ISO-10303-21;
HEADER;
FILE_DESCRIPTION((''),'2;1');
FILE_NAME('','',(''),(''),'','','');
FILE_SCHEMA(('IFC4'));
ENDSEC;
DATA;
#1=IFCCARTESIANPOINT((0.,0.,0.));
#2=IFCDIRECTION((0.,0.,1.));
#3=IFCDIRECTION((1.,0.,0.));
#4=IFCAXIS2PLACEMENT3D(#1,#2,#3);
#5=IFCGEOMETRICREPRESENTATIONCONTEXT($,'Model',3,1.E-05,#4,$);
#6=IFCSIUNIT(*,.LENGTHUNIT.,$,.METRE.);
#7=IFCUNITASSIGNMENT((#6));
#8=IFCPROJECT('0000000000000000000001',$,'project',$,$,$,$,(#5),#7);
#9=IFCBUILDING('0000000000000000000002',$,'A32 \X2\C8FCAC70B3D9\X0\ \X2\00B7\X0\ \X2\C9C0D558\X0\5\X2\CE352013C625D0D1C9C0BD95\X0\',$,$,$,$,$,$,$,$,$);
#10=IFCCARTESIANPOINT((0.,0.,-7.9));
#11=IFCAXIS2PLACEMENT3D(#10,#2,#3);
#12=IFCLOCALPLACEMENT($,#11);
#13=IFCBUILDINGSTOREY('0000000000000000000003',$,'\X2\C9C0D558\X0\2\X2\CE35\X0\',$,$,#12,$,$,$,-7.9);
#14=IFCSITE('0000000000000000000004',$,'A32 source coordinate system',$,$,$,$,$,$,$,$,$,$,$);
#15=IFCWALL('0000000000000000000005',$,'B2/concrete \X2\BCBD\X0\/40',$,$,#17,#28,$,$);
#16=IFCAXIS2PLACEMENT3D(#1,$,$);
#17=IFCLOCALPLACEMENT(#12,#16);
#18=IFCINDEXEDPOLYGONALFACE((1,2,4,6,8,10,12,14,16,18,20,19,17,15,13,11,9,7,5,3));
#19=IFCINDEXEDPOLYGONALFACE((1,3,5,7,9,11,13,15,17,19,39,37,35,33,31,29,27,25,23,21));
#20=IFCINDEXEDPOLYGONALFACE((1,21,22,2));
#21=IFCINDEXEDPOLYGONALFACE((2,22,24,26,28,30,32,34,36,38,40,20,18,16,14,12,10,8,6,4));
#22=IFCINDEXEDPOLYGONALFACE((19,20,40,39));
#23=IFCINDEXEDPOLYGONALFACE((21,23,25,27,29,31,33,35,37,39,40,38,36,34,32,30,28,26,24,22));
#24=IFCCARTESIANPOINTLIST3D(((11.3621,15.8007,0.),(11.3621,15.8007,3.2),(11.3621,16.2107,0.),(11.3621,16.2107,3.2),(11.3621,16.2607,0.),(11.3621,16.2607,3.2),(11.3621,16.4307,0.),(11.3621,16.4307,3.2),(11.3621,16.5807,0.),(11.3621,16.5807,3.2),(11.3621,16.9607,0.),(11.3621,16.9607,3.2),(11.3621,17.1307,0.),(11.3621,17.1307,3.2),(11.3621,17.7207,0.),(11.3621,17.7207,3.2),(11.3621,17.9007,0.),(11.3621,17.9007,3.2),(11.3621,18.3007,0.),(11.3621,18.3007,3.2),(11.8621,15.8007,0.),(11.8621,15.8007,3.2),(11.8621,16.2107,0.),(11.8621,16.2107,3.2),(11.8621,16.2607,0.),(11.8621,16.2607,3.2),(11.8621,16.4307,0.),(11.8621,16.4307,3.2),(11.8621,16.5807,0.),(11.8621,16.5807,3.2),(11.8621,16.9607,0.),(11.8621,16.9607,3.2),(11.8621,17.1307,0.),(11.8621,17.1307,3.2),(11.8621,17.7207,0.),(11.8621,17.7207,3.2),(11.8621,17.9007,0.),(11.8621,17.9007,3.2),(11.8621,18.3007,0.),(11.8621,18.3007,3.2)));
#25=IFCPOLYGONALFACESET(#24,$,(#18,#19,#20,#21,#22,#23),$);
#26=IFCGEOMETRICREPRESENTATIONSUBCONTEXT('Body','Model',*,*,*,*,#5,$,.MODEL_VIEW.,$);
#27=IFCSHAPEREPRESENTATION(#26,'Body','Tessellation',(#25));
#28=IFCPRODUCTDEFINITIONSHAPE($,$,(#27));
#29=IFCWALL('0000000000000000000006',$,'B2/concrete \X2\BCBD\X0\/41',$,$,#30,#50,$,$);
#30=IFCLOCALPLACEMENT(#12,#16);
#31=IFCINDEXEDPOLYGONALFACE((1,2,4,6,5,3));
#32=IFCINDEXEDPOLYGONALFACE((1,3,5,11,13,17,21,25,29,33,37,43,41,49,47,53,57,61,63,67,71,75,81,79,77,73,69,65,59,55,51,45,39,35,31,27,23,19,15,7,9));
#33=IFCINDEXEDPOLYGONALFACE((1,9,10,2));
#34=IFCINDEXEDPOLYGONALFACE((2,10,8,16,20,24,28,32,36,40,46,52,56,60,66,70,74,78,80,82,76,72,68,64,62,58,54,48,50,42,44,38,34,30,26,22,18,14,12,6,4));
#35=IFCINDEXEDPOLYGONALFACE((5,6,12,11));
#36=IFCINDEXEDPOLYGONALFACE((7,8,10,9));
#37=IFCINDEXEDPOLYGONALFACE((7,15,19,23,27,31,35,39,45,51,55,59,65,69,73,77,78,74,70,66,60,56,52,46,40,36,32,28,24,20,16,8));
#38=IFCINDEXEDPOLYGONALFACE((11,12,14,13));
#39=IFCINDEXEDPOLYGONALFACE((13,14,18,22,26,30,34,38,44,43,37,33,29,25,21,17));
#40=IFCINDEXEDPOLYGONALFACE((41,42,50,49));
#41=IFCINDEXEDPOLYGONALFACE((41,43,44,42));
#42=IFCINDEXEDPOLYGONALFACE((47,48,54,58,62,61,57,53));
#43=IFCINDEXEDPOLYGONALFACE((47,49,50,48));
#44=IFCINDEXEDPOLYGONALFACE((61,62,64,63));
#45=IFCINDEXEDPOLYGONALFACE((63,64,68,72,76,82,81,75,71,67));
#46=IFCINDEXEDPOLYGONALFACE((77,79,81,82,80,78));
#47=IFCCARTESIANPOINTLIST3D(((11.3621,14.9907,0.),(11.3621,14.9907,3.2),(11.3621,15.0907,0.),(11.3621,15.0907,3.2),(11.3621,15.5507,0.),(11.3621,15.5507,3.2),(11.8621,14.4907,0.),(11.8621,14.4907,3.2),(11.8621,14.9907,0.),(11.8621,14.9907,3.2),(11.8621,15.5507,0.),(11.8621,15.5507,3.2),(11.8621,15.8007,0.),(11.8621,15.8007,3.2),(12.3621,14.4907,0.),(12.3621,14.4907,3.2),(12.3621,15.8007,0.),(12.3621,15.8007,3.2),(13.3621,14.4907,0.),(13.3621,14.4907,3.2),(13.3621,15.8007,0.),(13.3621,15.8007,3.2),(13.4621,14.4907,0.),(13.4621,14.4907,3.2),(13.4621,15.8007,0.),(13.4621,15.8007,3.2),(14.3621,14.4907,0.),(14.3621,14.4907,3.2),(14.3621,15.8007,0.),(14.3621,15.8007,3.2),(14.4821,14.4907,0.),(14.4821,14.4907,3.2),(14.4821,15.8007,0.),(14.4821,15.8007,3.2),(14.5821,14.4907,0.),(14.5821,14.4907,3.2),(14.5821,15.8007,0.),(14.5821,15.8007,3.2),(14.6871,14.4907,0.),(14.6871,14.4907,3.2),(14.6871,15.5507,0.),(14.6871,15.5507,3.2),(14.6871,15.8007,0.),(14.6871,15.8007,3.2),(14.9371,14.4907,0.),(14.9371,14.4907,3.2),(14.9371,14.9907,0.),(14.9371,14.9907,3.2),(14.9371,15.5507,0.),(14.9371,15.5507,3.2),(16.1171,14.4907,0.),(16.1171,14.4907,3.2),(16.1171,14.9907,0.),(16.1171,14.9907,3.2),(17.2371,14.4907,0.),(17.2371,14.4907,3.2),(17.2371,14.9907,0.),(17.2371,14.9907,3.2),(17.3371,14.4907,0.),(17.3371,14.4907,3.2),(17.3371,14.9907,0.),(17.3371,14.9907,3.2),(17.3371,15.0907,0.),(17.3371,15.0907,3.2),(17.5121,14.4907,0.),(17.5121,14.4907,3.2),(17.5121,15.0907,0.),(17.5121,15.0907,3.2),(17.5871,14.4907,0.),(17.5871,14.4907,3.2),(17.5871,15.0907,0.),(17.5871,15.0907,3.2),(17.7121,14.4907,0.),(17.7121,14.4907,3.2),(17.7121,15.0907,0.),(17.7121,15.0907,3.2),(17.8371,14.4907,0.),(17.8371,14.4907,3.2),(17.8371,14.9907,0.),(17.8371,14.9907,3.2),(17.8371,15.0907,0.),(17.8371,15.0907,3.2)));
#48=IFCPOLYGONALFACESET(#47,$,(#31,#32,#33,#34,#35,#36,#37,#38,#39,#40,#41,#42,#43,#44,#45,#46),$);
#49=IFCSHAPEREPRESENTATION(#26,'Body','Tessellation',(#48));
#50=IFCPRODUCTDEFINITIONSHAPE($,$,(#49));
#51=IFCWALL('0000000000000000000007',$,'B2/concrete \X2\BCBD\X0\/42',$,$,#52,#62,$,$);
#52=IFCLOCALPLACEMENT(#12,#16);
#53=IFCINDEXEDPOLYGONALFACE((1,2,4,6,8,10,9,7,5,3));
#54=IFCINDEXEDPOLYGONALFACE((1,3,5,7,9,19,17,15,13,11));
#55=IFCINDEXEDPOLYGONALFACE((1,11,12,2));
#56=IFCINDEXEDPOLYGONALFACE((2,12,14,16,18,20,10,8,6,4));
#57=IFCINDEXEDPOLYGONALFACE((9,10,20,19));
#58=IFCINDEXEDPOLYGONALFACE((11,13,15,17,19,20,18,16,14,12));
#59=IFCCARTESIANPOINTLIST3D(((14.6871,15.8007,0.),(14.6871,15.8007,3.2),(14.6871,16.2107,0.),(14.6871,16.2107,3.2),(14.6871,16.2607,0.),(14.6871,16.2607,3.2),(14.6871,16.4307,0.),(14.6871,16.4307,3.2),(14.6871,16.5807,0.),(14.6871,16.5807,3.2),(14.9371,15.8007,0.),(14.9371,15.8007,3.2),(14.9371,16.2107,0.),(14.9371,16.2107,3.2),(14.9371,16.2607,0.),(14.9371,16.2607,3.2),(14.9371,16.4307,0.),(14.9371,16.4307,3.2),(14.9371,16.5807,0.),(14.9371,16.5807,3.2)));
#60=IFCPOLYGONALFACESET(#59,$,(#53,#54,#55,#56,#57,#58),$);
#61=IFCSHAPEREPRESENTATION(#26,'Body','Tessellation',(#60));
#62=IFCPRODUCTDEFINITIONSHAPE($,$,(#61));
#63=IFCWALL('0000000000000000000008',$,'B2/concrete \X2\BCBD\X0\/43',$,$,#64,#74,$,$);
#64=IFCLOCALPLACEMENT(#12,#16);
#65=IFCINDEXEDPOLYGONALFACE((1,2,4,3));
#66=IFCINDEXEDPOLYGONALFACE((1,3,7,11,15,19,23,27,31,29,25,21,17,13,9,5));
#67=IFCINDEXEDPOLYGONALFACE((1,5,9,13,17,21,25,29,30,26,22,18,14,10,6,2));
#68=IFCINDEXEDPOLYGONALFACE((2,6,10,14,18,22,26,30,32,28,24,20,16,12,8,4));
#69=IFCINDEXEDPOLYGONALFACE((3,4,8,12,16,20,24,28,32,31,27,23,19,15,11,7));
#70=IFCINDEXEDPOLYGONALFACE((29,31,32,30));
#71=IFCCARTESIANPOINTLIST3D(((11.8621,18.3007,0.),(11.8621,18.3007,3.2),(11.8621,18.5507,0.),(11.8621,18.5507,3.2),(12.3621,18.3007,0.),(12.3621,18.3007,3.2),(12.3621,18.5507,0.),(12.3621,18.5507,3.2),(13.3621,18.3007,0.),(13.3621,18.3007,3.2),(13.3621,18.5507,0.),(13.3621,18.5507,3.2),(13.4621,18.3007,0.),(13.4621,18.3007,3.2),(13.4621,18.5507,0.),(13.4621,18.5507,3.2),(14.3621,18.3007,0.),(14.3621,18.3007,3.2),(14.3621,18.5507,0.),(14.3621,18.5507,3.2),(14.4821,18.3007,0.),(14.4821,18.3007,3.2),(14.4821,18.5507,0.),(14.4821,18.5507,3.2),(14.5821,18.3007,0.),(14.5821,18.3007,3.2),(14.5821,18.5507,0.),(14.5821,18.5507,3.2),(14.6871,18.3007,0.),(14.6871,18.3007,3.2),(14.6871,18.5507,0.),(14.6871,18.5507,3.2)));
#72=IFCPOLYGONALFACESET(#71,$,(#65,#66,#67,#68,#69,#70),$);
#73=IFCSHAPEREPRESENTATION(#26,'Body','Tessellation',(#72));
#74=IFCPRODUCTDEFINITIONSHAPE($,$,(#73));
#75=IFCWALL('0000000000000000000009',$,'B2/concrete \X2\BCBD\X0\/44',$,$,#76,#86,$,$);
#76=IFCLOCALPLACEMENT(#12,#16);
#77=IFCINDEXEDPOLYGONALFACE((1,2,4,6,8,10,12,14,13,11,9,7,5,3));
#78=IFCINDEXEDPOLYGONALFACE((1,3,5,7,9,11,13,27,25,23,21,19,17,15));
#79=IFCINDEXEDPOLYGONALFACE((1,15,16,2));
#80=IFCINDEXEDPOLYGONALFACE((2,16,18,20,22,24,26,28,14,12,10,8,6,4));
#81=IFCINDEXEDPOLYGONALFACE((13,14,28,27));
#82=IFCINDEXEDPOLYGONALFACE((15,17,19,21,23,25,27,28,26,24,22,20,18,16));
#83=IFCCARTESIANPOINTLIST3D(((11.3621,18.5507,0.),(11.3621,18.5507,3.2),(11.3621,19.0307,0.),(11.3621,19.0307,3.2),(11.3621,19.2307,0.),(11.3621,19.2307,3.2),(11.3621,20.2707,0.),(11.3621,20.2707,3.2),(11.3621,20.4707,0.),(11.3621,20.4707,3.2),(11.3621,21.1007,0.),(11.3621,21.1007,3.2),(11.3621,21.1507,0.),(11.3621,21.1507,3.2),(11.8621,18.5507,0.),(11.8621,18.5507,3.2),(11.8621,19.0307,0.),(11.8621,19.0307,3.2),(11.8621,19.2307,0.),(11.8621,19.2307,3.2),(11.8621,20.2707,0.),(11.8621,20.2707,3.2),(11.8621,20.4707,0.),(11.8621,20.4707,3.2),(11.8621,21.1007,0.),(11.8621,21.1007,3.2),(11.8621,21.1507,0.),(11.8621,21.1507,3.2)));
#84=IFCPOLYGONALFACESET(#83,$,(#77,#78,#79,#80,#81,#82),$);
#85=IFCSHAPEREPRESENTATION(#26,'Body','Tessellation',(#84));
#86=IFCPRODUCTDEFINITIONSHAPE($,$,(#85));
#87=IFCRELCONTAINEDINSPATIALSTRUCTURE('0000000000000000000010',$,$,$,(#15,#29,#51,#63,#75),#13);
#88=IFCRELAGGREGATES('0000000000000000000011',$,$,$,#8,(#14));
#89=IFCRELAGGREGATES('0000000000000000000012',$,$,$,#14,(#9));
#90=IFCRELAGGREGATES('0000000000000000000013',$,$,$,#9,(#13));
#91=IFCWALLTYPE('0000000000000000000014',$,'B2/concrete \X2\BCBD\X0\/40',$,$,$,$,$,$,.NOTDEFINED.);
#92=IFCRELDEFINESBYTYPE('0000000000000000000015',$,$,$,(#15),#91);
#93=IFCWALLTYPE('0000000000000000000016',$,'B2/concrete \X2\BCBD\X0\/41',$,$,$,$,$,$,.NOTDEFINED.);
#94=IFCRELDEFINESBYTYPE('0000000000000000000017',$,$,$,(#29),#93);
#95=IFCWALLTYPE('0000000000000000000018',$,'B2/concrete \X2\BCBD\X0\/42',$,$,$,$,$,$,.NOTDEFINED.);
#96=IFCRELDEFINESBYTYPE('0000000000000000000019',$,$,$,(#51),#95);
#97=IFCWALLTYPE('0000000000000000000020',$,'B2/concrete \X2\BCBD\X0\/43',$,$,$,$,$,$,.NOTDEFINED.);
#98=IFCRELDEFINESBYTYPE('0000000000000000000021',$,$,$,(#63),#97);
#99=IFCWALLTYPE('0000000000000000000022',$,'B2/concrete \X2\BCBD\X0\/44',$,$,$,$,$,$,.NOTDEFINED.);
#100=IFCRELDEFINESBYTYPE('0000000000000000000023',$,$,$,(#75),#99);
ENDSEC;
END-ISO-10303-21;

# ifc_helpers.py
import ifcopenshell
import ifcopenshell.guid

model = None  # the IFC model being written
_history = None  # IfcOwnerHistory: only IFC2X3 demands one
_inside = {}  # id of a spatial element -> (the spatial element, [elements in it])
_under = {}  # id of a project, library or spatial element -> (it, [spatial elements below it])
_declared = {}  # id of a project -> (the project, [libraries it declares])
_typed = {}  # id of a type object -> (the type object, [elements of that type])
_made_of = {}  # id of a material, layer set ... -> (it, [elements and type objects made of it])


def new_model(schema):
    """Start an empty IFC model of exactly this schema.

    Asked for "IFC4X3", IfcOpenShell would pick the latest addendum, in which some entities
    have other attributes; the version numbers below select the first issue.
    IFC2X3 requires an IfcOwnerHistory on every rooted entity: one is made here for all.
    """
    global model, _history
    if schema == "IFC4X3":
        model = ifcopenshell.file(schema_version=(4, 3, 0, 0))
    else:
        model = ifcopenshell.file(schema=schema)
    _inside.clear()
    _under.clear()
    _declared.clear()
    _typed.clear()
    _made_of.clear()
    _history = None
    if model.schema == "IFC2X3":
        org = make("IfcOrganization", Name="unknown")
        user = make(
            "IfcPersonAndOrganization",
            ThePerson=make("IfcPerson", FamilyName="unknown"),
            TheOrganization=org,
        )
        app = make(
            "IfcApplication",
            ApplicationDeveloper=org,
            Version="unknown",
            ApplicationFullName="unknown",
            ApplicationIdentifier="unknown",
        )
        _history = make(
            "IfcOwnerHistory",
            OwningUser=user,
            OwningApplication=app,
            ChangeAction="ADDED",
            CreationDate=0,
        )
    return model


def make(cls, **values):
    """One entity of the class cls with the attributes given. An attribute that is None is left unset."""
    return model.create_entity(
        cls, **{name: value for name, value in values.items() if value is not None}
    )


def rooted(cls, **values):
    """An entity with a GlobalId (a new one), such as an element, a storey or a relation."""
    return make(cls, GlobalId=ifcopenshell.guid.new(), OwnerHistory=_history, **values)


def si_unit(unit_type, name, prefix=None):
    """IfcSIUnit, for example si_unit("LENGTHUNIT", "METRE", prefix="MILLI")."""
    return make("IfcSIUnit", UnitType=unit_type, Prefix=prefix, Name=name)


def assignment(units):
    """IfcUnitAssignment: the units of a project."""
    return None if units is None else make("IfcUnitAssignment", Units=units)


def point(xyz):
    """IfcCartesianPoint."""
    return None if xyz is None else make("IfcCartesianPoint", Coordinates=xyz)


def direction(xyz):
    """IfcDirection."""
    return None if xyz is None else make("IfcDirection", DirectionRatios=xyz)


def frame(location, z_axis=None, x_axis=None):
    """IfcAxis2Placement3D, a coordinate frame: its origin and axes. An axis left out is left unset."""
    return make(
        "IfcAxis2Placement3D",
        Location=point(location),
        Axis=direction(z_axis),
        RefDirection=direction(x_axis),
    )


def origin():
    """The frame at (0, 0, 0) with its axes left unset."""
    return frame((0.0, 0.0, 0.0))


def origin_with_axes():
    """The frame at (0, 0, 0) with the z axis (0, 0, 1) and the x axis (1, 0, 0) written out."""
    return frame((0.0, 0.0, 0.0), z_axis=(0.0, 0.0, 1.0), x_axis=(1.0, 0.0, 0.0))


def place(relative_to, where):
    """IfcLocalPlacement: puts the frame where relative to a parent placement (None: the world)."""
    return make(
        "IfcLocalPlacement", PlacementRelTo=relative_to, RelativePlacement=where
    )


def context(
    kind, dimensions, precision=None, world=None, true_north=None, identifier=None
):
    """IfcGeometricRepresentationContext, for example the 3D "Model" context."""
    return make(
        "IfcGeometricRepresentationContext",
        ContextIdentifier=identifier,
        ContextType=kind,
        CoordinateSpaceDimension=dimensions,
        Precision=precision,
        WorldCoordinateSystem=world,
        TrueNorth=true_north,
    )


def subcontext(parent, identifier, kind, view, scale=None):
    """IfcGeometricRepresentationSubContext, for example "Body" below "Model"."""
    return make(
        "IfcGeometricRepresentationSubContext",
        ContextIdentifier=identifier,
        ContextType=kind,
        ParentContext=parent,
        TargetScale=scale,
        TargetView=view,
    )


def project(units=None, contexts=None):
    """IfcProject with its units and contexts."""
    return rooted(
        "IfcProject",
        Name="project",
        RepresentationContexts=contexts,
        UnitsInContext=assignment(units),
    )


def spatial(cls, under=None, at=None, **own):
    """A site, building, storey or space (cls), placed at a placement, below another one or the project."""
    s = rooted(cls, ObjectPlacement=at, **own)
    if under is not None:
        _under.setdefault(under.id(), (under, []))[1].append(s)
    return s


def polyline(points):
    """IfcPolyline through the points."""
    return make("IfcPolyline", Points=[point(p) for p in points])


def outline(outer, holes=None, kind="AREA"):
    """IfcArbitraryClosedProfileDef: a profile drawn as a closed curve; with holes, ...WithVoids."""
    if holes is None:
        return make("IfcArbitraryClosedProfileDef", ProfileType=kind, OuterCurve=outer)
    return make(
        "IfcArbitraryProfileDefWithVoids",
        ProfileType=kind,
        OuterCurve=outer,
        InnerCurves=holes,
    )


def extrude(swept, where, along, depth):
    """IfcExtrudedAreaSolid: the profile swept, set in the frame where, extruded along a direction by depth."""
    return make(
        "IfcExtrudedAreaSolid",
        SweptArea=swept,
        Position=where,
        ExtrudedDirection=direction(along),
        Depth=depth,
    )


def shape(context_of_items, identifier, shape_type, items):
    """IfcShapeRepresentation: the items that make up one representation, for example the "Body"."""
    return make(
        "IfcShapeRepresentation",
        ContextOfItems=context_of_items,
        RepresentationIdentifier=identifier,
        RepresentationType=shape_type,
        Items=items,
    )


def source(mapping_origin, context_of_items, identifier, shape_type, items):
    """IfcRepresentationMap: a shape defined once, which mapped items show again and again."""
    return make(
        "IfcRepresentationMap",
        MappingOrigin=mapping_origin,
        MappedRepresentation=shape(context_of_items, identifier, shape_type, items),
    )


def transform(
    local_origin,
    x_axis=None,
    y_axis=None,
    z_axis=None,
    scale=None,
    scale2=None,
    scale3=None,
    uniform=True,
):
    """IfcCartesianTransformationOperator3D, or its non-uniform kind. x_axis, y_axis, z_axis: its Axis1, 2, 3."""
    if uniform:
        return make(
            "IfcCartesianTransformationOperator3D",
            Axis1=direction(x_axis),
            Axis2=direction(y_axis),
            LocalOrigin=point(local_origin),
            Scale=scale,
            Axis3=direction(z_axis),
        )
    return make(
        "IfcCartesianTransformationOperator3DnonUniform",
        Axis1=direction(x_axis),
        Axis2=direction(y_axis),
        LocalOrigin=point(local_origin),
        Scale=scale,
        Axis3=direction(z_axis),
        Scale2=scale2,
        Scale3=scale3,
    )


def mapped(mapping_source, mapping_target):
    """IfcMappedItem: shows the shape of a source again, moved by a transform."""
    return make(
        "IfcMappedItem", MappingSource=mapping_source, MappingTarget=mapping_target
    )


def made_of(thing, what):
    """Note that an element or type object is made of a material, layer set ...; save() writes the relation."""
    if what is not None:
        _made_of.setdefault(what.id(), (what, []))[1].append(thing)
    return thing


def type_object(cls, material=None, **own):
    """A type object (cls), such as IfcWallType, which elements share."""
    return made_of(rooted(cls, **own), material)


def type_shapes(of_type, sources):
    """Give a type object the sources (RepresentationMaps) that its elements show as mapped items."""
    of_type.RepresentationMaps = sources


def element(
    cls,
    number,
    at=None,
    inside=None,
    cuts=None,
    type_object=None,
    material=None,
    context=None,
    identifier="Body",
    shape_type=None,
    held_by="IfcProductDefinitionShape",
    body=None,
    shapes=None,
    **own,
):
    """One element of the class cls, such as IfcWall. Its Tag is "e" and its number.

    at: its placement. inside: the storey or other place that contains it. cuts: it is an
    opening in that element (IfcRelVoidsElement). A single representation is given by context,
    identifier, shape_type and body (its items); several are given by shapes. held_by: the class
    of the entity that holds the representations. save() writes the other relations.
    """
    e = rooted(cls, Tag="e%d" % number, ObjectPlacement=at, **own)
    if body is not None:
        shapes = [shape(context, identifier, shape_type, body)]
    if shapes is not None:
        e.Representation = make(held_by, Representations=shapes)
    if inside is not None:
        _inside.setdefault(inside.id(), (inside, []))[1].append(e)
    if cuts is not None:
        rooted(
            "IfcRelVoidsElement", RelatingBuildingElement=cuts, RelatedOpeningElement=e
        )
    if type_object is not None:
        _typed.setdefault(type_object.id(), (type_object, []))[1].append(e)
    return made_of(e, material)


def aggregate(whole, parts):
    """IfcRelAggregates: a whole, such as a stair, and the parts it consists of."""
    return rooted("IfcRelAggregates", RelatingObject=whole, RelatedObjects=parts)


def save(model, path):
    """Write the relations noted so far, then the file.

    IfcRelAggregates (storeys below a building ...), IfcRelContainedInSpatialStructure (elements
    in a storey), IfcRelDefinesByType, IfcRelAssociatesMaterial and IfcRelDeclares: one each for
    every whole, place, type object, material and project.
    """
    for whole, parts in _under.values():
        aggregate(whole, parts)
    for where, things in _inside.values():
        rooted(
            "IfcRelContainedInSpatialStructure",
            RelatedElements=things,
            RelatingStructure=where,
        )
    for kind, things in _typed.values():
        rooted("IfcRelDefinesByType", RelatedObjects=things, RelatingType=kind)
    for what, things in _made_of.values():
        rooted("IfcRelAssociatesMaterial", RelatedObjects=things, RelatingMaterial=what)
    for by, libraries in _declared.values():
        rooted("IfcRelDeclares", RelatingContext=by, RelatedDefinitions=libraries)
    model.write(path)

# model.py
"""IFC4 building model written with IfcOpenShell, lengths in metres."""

from ifc_helpers import new_model, si_unit, frame, origin, origin_with_axes, place, context, subcontext, project, spatial, polyline, outline, extrude, source, transform, mapped, type_object, type_shapes, element, save


model = new_model("IFC4")

# Units and contexts
model_context = context("Model", 3, precision=1e-05, world=origin_with_axes())
body_context = subcontext(model_context, "Body", "Model", "MODEL_VIEW")
ifc_project = project(units=[si_unit("LENGTHUNIT", "METRE")], contexts=[model_context])

# Site, building, storey
site = spatial("IfcSite", under=ifc_project, Name="A32 source coordinate system")
building = spatial("IfcBuilding", under=site, Name="A32 주거동 · 지하5층–옥탑지붕")
storey_placement = place(None, frame((0.0, 0.0, -7.9), z_axis=(0.0, 0.0, 1.0), x_axis=(1.0, 0.0, 0.0)))
storey = spatial("IfcBuildingStorey", under=building, at=storey_placement, Name="지하2층", Elevation=-7.9)

# Walls
wall_type_1 = type_object("IfcWallType", Name="B2/concrete 벽/40", PredefinedType="NOTDEFINED")
shared_shape_1 = source(origin(), body_context, "Body", "SweptSolid", [
    extrude(outline(polyline([(11.3621, 18.3007), (11.8621, 18.3007), (11.8621, 17.9007), (11.8621, 17.7207), (11.8621, 17.1307), (11.8621, 16.9607), (11.8621, 16.5807), (11.8621, 16.4307), (11.8621, 16.2607), (11.8621, 16.2107), (11.8621, 15.8007), (11.3621, 15.8007), (11.3621, 16.2107), (11.3621, 16.2607), (11.3621, 16.4307), (11.3621, 16.5807), (11.3621, 16.9607), (11.3621, 17.1307), (11.3621, 17.7207), (11.3621, 17.9007), (11.3621, 18.3007)])), origin(), (0.0, 0.0, 1.0), 3.2),
])
type_shapes(wall_type_1, [shared_shape_1])
wall_1_placement = place(storey_placement, origin_with_axes())
element("IfcWall", 1, at=wall_1_placement, inside=storey, type_object=wall_type_1, Name="B2/concrete 벽/40", context=body_context, shape_type="MappedRepresentation", body=[
    mapped(shared_shape_1, transform((0.0, 0.0, 0.0), scale=1.0)),
])
wall_type_2 = type_object("IfcWallType", Name="B2/concrete 벽/41", PredefinedType="NOTDEFINED")
shared_shape_2 = source(origin(), body_context, "Body", "SweptSolid", [
    extrude(outline(polyline([(13.4621, 15.8007), (14.3621, 15.8007), (14.4821, 15.8007), (14.5821, 15.8007), (14.6871, 15.8007), (14.6871, 15.5507), (14.9371, 15.5507), (14.9371, 14.9907), (16.1171, 14.9907), (17.2371, 14.9907), (17.3371, 14.9907), (17.3371, 15.0907), (17.5121, 15.0907), (17.5871, 15.0907), (17.7121, 15.0907), (17.8371, 15.0907), (17.8371, 14.9907), (17.8371, 14.4907), (17.7121, 14.4907), (17.5871, 14.4907), (17.5121, 14.4907), (17.3371, 14.4907), (17.2371, 14.4907), (16.1171, 14.4907), (14.9371, 14.4907), (14.6871, 14.4907), (14.5821, 14.4907), (14.4821, 14.4907), (14.3621, 14.4907), (13.4621, 14.4907), (13.3621, 14.4907), (12.3621, 14.4907), (11.8621, 14.4907), (11.8621, 14.9907), (11.3621, 14.9907), (11.3621, 15.0907), (11.3621, 15.5507), (11.8621, 15.5507), (11.8621, 15.8007), (12.3621, 15.8007), (13.3621, 15.8007), (13.4621, 15.8007)])), origin(), (0.0, 0.0, 1.0), 3.2),
])
type_shapes(wall_type_2, [shared_shape_2])
wall_2_placement = place(storey_placement, origin_with_axes())
element("IfcWall", 2, at=wall_2_placement, inside=storey, type_object=wall_type_2, Name="B2/concrete 벽/41", context=body_context, shape_type="MappedRepresentation", body=[
    mapped(shared_shape_2, transform((0.0, 0.0, 0.0), scale=1.0)),
])
wall_type_3 = type_object("IfcWallType", Name="B2/concrete 벽/42", PredefinedType="NOTDEFINED")
shared_shape_3 = source(origin(), body_context, "Body", "SweptSolid", [
    extrude(outline(polyline([(14.6871, 16.4307), (14.6871, 16.5807), (14.9371, 16.5807), (14.9371, 16.4307), (14.9371, 16.2607), (14.9371, 16.2107), (14.9371, 15.8007), (14.6871, 15.8007), (14.6871, 16.2107), (14.6871, 16.2607), (14.6871, 16.4307)])), origin(), (0.0, 0.0, 1.0), 3.2),
])
type_shapes(wall_type_3, [shared_shape_3])
wall_3_placement = place(storey_placement, origin_with_axes())
element("IfcWall", 3, at=wall_3_placement, inside=storey, type_object=wall_type_3, Name="B2/concrete 벽/42", context=body_context, shape_type="MappedRepresentation", body=[
    mapped(shared_shape_3, transform((0.0, 0.0, 0.0), scale=1.0)),
])
wall_type_4 = type_object("IfcWallType", Name="B2/concrete 벽/43", PredefinedType="NOTDEFINED")
shared_shape_4 = source(origin(), body_context, "Body", "SweptSolid", [
    extrude(outline(polyline([(13.3621, 18.5507), (13.4621, 18.5507), (14.3621, 18.5507), (14.4821, 18.5507), (14.5821, 18.5507), (14.6871, 18.5507), (14.6871, 18.3007), (14.5821, 18.3007), (14.4821, 18.3007), (14.3621, 18.3007), (13.4621, 18.3007), (13.3621, 18.3007), (12.3621, 18.3007), (11.8621, 18.3007), (11.8621, 18.5507), (12.3621, 18.5507), (13.3621, 18.5507)])), origin(), (0.0, 0.0, 1.0), 3.2),
])
type_shapes(wall_type_4, [shared_shape_4])
wall_4_placement = place(storey_placement, origin_with_axes())
element("IfcWall", 4, at=wall_4_placement, inside=storey, type_object=wall_type_4, Name="B2/concrete 벽/43", context=body_context, shape_type="MappedRepresentation", body=[
    mapped(shared_shape_4, transform((0.0, 0.0, 0.0), scale=1.0)),
])
wall_type_5 = type_object("IfcWallType", Name="B2/concrete 벽/44", PredefinedType="NOTDEFINED")
shared_shape_5 = source(origin(), body_context, "Body", "SweptSolid", [
    extrude(outline(polyline([(11.3621, 19.2307), (11.3621, 20.2707), (11.3621, 20.4707), (11.3621, 21.1007), (11.3621, 21.1507), (11.8621, 21.1507), (11.8621, 21.1007), (11.8621, 20.4707), (11.8621, 20.2707), (11.8621, 19.2307), (11.8621, 19.0307), (11.8621, 18.5507), (11.3621, 18.5507), (11.3621, 19.0307), (11.3621, 19.2307)])), origin(), (0.0, 0.0, 1.0), 3.2),
])
type_shapes(wall_type_5, [shared_shape_5])
wall_5_placement = place(storey_placement, origin_with_axes())
element("IfcWall", 5, at=wall_5_placement, inside=storey, type_object=wall_type_5, Name="B2/concrete 벽/44", context=body_context, shape_type="MappedRepresentation", body=[
    mapped(shared_shape_5, transform((0.0, 0.0, 0.0), scale=1.0)),
])

save(model, "model.ifc")
